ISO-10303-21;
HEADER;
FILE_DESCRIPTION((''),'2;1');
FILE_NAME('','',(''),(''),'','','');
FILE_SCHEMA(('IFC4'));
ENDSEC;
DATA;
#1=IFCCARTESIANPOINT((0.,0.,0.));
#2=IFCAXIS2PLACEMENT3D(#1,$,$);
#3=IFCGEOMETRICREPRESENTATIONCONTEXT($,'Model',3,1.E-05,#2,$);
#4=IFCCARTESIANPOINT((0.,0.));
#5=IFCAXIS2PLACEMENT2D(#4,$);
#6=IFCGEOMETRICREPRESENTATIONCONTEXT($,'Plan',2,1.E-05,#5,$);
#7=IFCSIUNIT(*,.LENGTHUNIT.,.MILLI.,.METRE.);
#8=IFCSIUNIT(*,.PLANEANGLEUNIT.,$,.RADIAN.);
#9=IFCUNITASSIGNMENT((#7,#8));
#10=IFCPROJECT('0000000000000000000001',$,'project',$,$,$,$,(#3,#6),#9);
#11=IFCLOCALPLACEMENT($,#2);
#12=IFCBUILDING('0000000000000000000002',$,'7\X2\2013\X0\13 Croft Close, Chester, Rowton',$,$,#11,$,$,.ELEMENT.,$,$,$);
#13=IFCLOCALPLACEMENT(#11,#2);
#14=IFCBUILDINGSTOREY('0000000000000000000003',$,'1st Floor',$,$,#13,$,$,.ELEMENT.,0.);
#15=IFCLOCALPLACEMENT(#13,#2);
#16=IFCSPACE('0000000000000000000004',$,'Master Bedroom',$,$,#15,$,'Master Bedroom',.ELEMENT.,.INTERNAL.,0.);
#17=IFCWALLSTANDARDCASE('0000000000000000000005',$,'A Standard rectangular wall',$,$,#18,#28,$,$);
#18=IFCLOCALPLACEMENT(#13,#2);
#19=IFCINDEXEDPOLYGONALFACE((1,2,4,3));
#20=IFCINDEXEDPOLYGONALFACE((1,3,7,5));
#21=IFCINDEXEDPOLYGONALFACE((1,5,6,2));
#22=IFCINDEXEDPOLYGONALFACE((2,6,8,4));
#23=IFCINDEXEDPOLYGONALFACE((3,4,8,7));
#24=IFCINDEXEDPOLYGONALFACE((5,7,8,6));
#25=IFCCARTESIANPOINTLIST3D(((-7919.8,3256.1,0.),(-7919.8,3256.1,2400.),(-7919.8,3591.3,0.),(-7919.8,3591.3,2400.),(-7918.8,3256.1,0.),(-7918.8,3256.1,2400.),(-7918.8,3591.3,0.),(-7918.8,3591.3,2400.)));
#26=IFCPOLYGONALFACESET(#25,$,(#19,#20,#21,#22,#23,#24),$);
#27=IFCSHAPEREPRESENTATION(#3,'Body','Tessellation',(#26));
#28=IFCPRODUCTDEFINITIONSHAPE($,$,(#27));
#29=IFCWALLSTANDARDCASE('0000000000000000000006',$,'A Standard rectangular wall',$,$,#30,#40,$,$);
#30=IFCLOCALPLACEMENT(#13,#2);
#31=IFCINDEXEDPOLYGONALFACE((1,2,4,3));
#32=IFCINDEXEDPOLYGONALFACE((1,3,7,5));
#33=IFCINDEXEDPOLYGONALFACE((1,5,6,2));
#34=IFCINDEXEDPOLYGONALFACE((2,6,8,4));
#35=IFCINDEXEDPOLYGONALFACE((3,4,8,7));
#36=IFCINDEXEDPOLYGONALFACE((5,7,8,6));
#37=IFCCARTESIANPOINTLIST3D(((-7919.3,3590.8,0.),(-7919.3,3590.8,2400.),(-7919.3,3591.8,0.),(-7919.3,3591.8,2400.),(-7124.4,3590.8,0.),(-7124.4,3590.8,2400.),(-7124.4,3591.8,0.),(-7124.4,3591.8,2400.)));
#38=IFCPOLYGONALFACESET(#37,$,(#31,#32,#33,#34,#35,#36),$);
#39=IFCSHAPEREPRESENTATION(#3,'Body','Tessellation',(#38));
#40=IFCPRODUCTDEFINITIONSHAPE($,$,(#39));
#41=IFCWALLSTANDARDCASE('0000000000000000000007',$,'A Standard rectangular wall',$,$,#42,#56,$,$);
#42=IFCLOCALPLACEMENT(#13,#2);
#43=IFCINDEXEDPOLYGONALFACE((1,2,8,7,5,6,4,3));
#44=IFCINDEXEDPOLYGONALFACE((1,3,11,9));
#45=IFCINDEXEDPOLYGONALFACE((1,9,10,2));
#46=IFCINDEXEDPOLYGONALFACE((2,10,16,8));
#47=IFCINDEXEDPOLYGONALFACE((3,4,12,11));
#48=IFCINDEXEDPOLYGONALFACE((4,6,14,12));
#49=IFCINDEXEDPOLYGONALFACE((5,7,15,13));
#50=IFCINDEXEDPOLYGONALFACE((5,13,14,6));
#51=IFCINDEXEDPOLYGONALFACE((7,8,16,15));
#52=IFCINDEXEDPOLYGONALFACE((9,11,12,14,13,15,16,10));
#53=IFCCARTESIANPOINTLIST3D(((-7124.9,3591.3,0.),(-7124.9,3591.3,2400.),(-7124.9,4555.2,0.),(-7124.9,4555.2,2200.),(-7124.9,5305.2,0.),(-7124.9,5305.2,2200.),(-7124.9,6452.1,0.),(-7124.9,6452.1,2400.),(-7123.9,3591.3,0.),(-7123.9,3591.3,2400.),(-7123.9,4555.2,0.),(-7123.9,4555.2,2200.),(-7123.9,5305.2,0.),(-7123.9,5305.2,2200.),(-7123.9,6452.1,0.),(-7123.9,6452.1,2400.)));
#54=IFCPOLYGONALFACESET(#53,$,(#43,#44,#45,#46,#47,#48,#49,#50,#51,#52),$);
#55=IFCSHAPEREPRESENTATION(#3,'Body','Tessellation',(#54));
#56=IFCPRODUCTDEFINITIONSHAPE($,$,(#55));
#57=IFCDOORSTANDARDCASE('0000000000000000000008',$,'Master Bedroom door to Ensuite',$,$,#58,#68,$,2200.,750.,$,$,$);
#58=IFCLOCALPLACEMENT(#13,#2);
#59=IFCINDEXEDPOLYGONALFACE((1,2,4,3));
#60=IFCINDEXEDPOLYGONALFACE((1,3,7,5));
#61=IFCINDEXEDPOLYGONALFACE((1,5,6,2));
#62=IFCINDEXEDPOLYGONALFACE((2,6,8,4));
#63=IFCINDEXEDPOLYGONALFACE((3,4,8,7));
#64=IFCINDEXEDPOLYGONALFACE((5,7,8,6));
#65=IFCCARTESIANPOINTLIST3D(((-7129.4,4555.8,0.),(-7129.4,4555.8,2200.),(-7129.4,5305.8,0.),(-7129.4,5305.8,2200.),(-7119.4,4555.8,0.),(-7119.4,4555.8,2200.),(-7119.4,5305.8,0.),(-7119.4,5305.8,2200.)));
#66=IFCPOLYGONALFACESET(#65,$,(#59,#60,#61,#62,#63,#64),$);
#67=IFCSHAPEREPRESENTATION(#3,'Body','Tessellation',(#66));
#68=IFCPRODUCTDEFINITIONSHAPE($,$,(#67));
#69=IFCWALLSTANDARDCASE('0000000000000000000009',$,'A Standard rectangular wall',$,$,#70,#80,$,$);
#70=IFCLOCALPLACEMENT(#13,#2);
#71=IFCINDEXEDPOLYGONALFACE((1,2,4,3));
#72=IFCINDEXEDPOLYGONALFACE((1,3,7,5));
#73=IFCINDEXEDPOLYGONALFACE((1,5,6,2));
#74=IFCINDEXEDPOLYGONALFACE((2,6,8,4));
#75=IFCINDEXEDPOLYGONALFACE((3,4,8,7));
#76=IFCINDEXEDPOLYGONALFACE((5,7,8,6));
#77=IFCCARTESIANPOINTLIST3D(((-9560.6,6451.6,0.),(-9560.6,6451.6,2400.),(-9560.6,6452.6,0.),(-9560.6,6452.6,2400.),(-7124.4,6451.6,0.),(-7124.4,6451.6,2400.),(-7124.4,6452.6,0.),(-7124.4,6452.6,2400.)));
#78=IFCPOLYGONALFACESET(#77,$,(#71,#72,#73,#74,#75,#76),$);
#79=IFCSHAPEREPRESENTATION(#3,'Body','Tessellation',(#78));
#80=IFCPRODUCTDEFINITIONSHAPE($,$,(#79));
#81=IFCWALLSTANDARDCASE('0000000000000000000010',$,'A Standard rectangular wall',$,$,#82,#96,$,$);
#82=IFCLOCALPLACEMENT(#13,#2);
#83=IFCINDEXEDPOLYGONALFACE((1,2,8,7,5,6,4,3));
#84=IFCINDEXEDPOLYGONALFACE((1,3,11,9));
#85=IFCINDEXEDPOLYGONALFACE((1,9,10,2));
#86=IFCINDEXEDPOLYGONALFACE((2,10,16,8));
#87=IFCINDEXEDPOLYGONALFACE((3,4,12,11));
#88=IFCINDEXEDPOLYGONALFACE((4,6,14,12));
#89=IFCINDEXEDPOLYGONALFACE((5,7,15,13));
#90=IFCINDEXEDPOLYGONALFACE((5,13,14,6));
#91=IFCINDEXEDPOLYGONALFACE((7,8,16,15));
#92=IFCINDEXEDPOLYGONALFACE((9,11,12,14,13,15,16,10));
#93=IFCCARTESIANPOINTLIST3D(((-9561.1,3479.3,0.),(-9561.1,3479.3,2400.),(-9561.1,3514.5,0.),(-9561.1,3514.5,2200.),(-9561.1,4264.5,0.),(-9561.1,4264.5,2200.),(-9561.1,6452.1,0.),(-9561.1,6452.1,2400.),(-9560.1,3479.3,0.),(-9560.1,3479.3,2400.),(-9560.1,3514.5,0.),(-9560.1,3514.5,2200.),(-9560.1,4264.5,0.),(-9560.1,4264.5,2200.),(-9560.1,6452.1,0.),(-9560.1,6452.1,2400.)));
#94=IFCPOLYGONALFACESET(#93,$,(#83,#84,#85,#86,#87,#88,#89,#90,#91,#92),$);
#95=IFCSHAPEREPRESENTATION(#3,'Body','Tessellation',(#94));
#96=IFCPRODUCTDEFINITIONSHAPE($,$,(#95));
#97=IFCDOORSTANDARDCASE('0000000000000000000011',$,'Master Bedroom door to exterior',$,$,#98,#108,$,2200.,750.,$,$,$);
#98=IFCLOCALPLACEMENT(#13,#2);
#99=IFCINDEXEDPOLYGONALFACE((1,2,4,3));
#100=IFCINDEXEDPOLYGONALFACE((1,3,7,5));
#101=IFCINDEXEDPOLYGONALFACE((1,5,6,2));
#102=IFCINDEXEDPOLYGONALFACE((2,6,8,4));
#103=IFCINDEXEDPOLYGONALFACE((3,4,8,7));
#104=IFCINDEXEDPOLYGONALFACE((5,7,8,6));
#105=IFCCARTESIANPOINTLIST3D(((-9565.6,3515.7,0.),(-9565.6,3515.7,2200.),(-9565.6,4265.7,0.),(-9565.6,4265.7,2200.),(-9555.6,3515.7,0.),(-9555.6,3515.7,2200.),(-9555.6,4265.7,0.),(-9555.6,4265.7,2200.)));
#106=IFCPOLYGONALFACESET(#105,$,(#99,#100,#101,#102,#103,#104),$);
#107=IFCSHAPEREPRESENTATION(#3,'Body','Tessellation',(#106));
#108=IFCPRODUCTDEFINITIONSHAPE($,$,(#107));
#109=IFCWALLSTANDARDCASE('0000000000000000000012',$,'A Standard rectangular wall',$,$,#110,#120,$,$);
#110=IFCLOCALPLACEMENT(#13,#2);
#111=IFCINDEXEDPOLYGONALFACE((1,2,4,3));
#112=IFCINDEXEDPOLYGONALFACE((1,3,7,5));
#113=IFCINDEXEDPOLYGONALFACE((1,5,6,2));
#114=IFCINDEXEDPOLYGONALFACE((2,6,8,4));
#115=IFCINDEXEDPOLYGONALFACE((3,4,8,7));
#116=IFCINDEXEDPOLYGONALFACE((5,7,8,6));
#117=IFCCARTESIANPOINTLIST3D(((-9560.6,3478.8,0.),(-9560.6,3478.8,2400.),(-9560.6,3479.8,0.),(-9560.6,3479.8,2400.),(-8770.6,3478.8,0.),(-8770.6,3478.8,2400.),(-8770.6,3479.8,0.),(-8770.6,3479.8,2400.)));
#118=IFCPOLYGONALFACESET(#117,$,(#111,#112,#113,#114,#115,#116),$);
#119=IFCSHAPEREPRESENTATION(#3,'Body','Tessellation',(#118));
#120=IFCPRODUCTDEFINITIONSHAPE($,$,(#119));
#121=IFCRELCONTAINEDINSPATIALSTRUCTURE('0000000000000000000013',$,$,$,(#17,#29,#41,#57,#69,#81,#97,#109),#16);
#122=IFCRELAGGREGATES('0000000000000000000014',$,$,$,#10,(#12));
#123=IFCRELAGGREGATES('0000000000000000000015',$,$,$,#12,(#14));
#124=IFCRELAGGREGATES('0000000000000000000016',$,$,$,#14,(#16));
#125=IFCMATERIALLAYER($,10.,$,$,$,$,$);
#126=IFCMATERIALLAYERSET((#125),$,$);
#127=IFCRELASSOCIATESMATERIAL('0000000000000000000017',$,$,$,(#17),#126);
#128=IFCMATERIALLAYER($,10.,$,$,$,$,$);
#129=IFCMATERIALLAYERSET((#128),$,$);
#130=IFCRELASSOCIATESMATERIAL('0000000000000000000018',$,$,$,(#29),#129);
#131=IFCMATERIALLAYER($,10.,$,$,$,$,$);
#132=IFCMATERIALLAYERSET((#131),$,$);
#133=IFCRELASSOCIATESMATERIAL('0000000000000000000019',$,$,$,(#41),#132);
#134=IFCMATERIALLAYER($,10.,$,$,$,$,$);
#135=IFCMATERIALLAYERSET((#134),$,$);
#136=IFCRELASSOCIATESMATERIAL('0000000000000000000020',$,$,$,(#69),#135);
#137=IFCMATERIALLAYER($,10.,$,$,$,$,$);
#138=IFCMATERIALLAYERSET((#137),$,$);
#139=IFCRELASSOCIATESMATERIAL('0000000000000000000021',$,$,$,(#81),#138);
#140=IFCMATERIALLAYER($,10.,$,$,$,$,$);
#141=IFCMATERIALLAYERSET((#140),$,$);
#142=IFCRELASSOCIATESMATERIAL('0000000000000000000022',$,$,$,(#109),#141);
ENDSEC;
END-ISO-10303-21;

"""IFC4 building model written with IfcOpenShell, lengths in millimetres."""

from ifc_helpers import new_model, si_unit, frame, origin, origin_2d, place, context, project, spatial, rectangle, extrude, layer, layer_set, layer_usage, element, fill, save


model = new_model("IFC4")

# Units and contexts
model_context = context("Model", 3, precision=1e-05, world=origin())
plan_context = context("Plan", 2, precision=1e-05, world=origin_2d())
ifc_project = project(units=[si_unit("LENGTHUNIT", "METRE", prefix="MILLI"), si_unit("PLANEANGLEUNIT", "RADIAN")], contexts=[model_context, plan_context])

# Building, storey
building_placement = place(None, origin())
building = spatial("IfcBuilding", under=ifc_project, at=building_placement, Name="7–13 Croft Close, Chester, Rowton", CompositionType="ELEMENT")
storey_placement = place(building_placement, origin())
storey = spatial("IfcBuildingStorey", under=building, at=storey_placement, Name="1st Floor", CompositionType="ELEMENT", Elevation=0.0)

# Shared definitions
space_1_placement = place(storey_placement, origin())
space_1 = spatial("IfcSpace", under=storey, at=space_1_placement, Name="Master Bedroom", LongName="Master Bedroom", CompositionType="ELEMENT", PredefinedType="INTERNAL", ElevationWithFlooring=0.0)

# Walls
ifc_layer_1 = layer(None, 10.0)
ifc_layer_set_1 = layer_set([ifc_layer_1])
ifc_layer_usage_1 = layer_usage(ifc_layer_set_1, "AXIS2", "NEGATIVE", 150.0)
wall_1_placement = place(storey_placement, origin())
element("IfcWallStandardCase", 1, at=wall_1_placement, inside=space_1, material=ifc_layer_usage_1, Name="A Standard rectangular wall", context=model_context, shape_type="SweptSolid", body=[
    extrude(rectangle(XDim=1.0, YDim=335.2, at=origin_2d()), frame((-7919.3, 3423.7, 0.0), x_axis=(-1.0, 0.0, 0.0)), (0.0, 0.0, 1.0), 2400.0),
])
ifc_layer_2 = layer(None, 10.0)
ifc_layer_set_2 = layer_set([ifc_layer_2])
ifc_layer_usage_2 = layer_usage(ifc_layer_set_2, "AXIS2", "NEGATIVE", 150.0)
wall_2_placement = place(storey_placement, origin())
element("IfcWallStandardCase", 2, at=wall_2_placement, inside=space_1, material=ifc_layer_usage_2, Name="A Standard rectangular wall", context=model_context, shape_type="SweptSolid", body=[
    extrude(rectangle(XDim=1.0, YDim=794.9, at=origin_2d()), frame((-7521.9, 3591.3, 0.0), x_axis=(0.0, 1.0, 0.0)), (0.0, 0.0, 1.0), 2400.0),
])

# Wall, opening, door
ifc_layer_3 = layer(None, 10.0)
ifc_layer_set_3 = layer_set([ifc_layer_3])
ifc_layer_usage_3 = layer_usage(ifc_layer_set_3, "AXIS2", "NEGATIVE", 150.0)
wall_3_placement = place(storey_placement, origin())
wall_3 = element("IfcWallStandardCase", 3, at=wall_3_placement, inside=space_1, material=ifc_layer_usage_3, Name="A Standard rectangular wall", context=model_context, shape_type="SweptSolid", body=[
    extrude(rectangle(XDim=1.0, YDim=2860.8, at=origin_2d()), frame((-7124.4, 5021.7, 0.0), x_axis=(-1.0, 0.0, 0.0)), (0.0, 0.0, 1.0), 2400.0),
])
opening_1_placement = place(storey_placement, origin())
opening_1 = element("IfcOpeningElement", 4, at=opening_1_placement, cuts=wall_3, context=model_context, shape_type="SweptSolid", body=[
    extrude(rectangle(XDim=10.0, YDim=750.0, at=origin_2d()), frame((-7124.4, 4930.2, 0.0), x_axis=(-1.0, 0.0, 0.0)), (0.0, 0.0, 1.0), 2200.0),
])
door_1_placement = place(storey_placement, frame((0.0, 0.6, 0.0)))
door_1 = element("IfcDoorStandardCase", 5, at=door_1_placement, inside=space_1, Name="Master Bedroom door to Ensuite", OverallHeight=2200.0, OverallWidth=750.0, context=model_context, shape_type="SweptSolid", body=[
    extrude(rectangle(XDim=10.0, YDim=750.0, at=origin_2d()), frame((-7124.4, 4930.2, 0.0), x_axis=(-1.0, 0.0, 0.0)), (0.0, 0.0, 1.0), 2200.0),
])
fill(opening_1, door_1)

# Wall
ifc_layer_4 = layer(None, 10.0)
ifc_layer_set_4 = layer_set([ifc_layer_4])
ifc_layer_usage_4 = layer_usage(ifc_layer_set_4, "AXIS2", "NEGATIVE", 150.0)
wall_4_placement = place(storey_placement, origin())
element("IfcWallStandardCase", 6, at=wall_4_placement, inside=space_1, material=ifc_layer_usage_4, Name="A Standard rectangular wall", context=model_context, shape_type="SweptSolid", body=[
    extrude(rectangle(XDim=1.0, YDim=2436.2, at=origin_2d()), frame((-8342.5, 6452.1, 0.0), x_axis=(0.0, -1.0, 0.0)), (0.0, 0.0, 1.0), 2400.0),
])

# Wall, opening, door
ifc_layer_5 = layer(None, 10.0)
ifc_layer_set_5 = layer_set([ifc_layer_5])
ifc_layer_usage_5 = layer_usage(ifc_layer_set_5, "AXIS2", "NEGATIVE", 150.0)
wall_5_placement = place(storey_placement, origin())
wall_5 = element("IfcWallStandardCase", 7, at=wall_5_placement, inside=space_1, material=ifc_layer_usage_5, Name="A Standard rectangular wall", context=model_context, shape_type="SweptSolid", body=[
    extrude(rectangle(XDim=1.0, YDim=2972.8, at=origin_2d()), frame((-9560.6, 4965.7, 0.0), x_axis=(1.0, 0.0, 0.0)), (0.0, 0.0, 1.0), 2400.0),
])
opening_2_placement = place(storey_placement, origin())
opening_2 = element("IfcOpeningElement", 8, at=opening_2_placement, cuts=wall_5, context=model_context, shape_type="SweptSolid", body=[
    extrude(rectangle(XDim=10.0, YDim=750.0, at=origin_2d()), frame((-9560.6, 3889.5, 0.0), x_axis=(-1.0, 0.0, 0.0)), (0.0, 0.0, 1.0), 2200.0),
])
door_2_placement = place(storey_placement, frame((0.0, 1.2, 0.0)))
door_2 = element("IfcDoorStandardCase", 9, at=door_2_placement, inside=space_1, Name="Master Bedroom door to exterior", OverallHeight=2200.0, OverallWidth=750.0, context=model_context, shape_type="SweptSolid", body=[
    extrude(rectangle(XDim=10.0, YDim=750.0, at=origin_2d()), frame((-9560.6, 3889.5, 0.0), x_axis=(-1.0, 0.0, 0.0)), (0.0, 0.0, 1.0), 2200.0),
])
fill(opening_2, door_2)

# Wall
ifc_layer_6 = layer(None, 10.0)
ifc_layer_set_6 = layer_set([ifc_layer_6])
ifc_layer_usage_6 = layer_usage(ifc_layer_set_6, "AXIS2", "NEGATIVE", 150.0)
wall_6_placement = place(storey_placement, origin())
element("IfcWallStandardCase", 10, at=wall_6_placement, inside=space_1, material=ifc_layer_usage_6, Name="A Standard rectangular wall", context=model_context, shape_type="SweptSolid", body=[
    extrude(rectangle(XDim=1.0, YDim=790.0, at=origin_2d()), frame((-9165.6, 3479.3, 0.0), x_axis=(0.0, 1.0, 0.0)), (0.0, 0.0, 1.0), 2400.0),
])

save(model, "model.ifc")
